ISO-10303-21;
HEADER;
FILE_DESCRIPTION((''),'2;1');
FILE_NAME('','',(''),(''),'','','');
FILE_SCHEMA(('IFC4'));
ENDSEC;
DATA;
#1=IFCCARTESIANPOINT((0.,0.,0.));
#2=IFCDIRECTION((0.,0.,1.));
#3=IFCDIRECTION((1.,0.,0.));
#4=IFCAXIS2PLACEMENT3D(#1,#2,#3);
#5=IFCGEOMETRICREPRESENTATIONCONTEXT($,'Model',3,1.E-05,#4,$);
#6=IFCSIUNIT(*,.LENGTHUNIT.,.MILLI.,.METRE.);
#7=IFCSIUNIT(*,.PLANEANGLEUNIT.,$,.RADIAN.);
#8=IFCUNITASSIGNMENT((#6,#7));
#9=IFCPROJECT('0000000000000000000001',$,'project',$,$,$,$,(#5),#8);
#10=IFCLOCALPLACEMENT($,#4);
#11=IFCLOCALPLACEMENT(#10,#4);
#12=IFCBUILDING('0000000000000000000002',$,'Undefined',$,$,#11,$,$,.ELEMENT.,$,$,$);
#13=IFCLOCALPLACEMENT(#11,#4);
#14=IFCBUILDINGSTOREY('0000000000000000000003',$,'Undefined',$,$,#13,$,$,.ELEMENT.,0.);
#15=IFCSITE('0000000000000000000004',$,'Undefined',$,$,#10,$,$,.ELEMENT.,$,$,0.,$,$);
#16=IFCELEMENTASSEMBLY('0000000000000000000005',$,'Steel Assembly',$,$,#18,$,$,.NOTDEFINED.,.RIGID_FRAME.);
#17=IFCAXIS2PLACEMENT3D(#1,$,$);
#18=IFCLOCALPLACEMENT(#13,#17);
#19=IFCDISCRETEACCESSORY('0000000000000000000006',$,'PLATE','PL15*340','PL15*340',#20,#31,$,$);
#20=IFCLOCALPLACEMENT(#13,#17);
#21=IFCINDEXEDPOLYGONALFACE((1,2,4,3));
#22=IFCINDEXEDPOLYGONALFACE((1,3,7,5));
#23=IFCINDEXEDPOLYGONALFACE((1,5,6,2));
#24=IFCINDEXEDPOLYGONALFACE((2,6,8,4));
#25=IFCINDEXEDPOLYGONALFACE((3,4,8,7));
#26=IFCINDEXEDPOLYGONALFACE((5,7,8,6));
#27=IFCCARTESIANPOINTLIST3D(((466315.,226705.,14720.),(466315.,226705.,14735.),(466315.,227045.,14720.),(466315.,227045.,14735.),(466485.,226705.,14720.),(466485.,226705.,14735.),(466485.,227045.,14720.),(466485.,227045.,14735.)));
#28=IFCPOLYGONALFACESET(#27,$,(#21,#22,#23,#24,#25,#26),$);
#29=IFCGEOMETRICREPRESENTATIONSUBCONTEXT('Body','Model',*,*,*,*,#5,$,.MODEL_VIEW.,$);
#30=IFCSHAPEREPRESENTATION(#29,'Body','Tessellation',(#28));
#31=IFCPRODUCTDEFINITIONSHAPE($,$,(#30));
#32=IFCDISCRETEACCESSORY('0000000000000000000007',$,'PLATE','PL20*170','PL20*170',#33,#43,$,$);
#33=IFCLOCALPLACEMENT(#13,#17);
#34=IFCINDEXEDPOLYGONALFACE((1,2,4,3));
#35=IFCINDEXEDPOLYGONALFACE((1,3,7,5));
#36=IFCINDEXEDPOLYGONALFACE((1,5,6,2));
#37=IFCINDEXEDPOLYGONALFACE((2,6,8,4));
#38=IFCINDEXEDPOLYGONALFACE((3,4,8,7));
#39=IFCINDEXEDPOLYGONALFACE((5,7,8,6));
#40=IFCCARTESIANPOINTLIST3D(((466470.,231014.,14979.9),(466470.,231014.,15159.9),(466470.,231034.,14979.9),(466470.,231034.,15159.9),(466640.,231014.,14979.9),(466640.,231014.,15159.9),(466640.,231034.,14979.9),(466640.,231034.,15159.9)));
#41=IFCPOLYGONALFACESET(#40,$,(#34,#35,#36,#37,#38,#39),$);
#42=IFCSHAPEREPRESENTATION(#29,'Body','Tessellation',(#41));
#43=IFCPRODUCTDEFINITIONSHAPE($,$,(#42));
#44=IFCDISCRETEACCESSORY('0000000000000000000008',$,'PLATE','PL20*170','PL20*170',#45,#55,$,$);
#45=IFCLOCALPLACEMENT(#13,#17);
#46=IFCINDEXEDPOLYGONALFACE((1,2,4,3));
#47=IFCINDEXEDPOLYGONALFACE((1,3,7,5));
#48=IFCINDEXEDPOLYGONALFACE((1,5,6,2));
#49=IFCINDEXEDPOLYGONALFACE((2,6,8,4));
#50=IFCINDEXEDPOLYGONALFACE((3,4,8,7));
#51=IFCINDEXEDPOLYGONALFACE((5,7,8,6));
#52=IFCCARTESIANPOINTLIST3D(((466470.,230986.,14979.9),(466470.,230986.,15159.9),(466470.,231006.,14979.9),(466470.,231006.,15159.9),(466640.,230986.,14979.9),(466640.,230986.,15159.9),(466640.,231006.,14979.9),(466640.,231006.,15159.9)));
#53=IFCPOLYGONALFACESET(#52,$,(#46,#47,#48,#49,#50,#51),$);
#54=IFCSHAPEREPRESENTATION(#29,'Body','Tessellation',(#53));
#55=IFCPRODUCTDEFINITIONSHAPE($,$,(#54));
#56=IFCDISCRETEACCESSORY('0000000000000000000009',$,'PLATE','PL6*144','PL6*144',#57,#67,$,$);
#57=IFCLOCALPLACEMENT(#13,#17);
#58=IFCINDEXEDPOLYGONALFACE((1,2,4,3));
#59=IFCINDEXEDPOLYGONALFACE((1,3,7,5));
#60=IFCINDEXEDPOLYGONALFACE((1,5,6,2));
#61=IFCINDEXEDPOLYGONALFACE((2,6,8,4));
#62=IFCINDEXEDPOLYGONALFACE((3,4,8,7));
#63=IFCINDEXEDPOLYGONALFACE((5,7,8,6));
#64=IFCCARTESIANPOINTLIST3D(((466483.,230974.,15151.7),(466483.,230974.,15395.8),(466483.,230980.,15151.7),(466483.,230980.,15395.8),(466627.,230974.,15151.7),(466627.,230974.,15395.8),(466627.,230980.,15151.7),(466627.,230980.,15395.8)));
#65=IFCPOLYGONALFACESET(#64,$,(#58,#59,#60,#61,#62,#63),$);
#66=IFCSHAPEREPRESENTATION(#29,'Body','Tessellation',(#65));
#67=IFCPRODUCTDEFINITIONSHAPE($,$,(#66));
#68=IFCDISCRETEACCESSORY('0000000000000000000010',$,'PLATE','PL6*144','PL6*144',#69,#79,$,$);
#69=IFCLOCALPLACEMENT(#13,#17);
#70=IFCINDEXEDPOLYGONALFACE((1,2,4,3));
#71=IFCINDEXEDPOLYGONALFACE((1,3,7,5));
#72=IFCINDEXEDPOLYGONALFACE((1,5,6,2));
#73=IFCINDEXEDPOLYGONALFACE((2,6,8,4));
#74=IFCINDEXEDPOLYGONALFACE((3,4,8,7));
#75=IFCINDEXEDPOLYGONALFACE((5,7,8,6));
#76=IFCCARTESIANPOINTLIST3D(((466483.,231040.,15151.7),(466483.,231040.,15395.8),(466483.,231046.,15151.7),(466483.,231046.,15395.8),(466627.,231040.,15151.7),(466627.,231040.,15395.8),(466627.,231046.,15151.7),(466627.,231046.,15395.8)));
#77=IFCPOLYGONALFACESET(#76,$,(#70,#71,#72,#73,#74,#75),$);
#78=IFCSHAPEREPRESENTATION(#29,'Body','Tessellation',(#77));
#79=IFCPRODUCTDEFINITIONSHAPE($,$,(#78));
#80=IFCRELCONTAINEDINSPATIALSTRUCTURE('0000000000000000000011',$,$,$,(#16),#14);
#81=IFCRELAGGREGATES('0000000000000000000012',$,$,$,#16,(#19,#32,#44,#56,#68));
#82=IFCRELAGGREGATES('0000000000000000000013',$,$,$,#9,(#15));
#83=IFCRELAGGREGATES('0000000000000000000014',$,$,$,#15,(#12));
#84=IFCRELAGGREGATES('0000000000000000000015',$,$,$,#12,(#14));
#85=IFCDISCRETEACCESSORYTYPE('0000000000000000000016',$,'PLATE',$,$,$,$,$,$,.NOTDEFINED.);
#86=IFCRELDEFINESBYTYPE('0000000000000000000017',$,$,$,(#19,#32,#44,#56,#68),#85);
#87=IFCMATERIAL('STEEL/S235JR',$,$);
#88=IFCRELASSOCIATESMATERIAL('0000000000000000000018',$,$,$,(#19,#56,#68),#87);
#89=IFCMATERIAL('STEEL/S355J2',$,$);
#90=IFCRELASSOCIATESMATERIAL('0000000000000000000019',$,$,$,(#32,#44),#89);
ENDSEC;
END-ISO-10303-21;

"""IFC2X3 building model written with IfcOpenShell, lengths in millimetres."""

from ifc_helpers import new_model, si_unit, frame, origin_with_axes, origin_2d_with_axis, place, context, subcontext, project, spatial, polyline, rectangle, outline, extrude, material, type_object, element, aggregate, save


model = new_model("IFC2X3")

# Units and contexts
model_context = context("Model", 3, precision=1e-05, world=origin_with_axes())
body_context = subcontext(model_context, "Body", "Model", "MODEL_VIEW")
ifc_project = project(units=[si_unit("LENGTHUNIT", "METRE", prefix="MILLI"), si_unit("PLANEANGLEUNIT", "RADIAN")], contexts=[model_context])

# Site, building, storey
site_placement = place(None, origin_with_axes())
site = spatial("IfcSite", under=ifc_project, at=site_placement, Name="Undefined", CompositionType="ELEMENT", RefElevation=0.0)
building_placement = place(site_placement, origin_with_axes())
building = spatial("IfcBuilding", under=site, at=building_placement, Name="Undefined", CompositionType="ELEMENT")
storey_placement = place(building_placement, origin_with_axes())
storey = spatial("IfcBuildingStorey", under=building, at=storey_placement, Name="Undefined", CompositionType="ELEMENT", Elevation=0.0)

# Shared definitions
ifc_material_1 = material(Name="STEEL/S355J2")

# Element assembly, discrete accessories
assembly_1_placement = place(storey_placement, origin_with_axes())
assembly_1 = element("IfcElementAssembly", 1, at=assembly_1_placement, inside=storey, Name="Steel Assembly", AssemblyPlace="NOTDEFINED", PredefinedType="RIGID_FRAME")
ifc_material_2 = material(Name="STEEL/S235JR")
discrete_accessory_type_1 = type_object("IfcDiscreteAccessoryType", Name="PLATE")
discrete_accessory_1_placement = place(assembly_1_placement, frame((466485.0, 226875.0, 14727.5), z_axis=(0.0, 0.0, 1.0), x_axis=(-1.0, 0.0, 0.0)))
discrete_accessory_1 = element("IfcDiscreteAccessory", 2, at=discrete_accessory_1_placement, type_object=discrete_accessory_type_1, material=ifc_material_2, Name="PLATE", Description="PL15*340", ObjectType="PL15*340", context=body_context, shape_type="SweptSolid", body=[
    extrude(outline(polyline([(170.0, -170.0), (0.0, -170.0), (0.0, 170.0), (170.0, 170.0), (170.0, -170.0)])), frame((0.0, 0.0, -7.5), z_axis=(0.0, 0.0, 1.0), x_axis=(1.0, 0.0, 0.0)), (0.0, 0.0, 1.0), 15.0),
])
discrete_accessory_2_placement = place(assembly_1_placement, frame((466470.0, 231024.0, 14979.9), z_axis=(0.0, 1.0, 0.0), x_axis=(0.0, 0.0, 1.0)))
discrete_accessory_2 = element("IfcDiscreteAccessory", 3, at=discrete_accessory_2_placement, type_object=discrete_accessory_type_1, material=ifc_material_1, Name="PLATE", Description="PL20*170", ObjectType="PL20*170", context=body_context, shape_type="SweptSolid", body=[
    extrude(outline(polyline([(0.0, 0.0), (180.0, 0.0), (180.0, 170.0), (0.0, 170.0), (0.0, 0.0)])), frame((0.0, 0.0, -10.0), z_axis=(0.0, 0.0, 1.0), x_axis=(1.0, 0.0, 0.0)), (0.0, 0.0, 1.0), 20.0),
])
discrete_accessory_3_placement = place(assembly_1_placement, frame((466470.0, 230996.0, 14979.9), z_axis=(0.0, 1.0, 0.0), x_axis=(0.0, 0.0, 1.0)))
discrete_accessory_3 = element("IfcDiscreteAccessory", 4, at=discrete_accessory_3_placement, type_object=discrete_accessory_type_1, material=ifc_material_1, Name="PLATE", Description="PL20*170", ObjectType="PL20*170", context=body_context, shape_type="SweptSolid", body=[
    extrude(outline(polyline([(0.0, 0.0), (180.0, 0.0), (180.0, 170.0), (0.0, 170.0), (0.0, 0.0)])), frame((0.0, 0.0, -10.0), z_axis=(0.0, 0.0, 1.0), x_axis=(1.0, 0.0, 0.0)), (0.0, 0.0, 1.0), 20.0),
])
discrete_accessory_4_placement = place(assembly_1_placement, frame((466555.0, 230977.0, 15151.7), z_axis=(0.0, 0.0, 1.0), x_axis=(1.0, 0.0, 0.0)))
discrete_accessory_4 = element("IfcDiscreteAccessory", 5, at=discrete_accessory_4_placement, type_object=discrete_accessory_type_1, material=ifc_material_2, Name="PLATE", Description="PL6*144", ObjectType="PL6*144", context=body_context, shape_type="SweptSolid", body=[
    extrude(rectangle(XDim=6.0, YDim=144.0, at=origin_2d_with_axis()), frame((0.0, 0.0, 244.1), z_axis=(0.0, 0.0, -1.0), x_axis=(0.0, -1.0, 0.0)), (0.0, 0.0, 1.0), 244.1),
])
discrete_accessory_5_placement = place(assembly_1_placement, frame((466555.0, 231043.0, 15151.7), z_axis=(0.0, 0.0, 1.0), x_axis=(1.0, 0.0, 0.0)))
discrete_accessory_5 = element("IfcDiscreteAccessory", 6, at=discrete_accessory_5_placement, type_object=discrete_accessory_type_1, material=ifc_material_2, Name="PLATE", Description="PL6*144", ObjectType="PL6*144", context=body_context, shape_type="SweptSolid", body=[
    extrude(rectangle(XDim=6.0, YDim=144.0, at=origin_2d_with_axis()), frame((0.0, 0.0, 244.1), z_axis=(0.0, 0.0, -1.0), x_axis=(0.0, 1.0, 0.0)), (0.0, 0.0, 1.0), 244.1),
])
aggregate(assembly_1, [discrete_accessory_1, discrete_accessory_2, discrete_accessory_3, discrete_accessory_4, discrete_accessory_5])

save(model, "model.ifc")
